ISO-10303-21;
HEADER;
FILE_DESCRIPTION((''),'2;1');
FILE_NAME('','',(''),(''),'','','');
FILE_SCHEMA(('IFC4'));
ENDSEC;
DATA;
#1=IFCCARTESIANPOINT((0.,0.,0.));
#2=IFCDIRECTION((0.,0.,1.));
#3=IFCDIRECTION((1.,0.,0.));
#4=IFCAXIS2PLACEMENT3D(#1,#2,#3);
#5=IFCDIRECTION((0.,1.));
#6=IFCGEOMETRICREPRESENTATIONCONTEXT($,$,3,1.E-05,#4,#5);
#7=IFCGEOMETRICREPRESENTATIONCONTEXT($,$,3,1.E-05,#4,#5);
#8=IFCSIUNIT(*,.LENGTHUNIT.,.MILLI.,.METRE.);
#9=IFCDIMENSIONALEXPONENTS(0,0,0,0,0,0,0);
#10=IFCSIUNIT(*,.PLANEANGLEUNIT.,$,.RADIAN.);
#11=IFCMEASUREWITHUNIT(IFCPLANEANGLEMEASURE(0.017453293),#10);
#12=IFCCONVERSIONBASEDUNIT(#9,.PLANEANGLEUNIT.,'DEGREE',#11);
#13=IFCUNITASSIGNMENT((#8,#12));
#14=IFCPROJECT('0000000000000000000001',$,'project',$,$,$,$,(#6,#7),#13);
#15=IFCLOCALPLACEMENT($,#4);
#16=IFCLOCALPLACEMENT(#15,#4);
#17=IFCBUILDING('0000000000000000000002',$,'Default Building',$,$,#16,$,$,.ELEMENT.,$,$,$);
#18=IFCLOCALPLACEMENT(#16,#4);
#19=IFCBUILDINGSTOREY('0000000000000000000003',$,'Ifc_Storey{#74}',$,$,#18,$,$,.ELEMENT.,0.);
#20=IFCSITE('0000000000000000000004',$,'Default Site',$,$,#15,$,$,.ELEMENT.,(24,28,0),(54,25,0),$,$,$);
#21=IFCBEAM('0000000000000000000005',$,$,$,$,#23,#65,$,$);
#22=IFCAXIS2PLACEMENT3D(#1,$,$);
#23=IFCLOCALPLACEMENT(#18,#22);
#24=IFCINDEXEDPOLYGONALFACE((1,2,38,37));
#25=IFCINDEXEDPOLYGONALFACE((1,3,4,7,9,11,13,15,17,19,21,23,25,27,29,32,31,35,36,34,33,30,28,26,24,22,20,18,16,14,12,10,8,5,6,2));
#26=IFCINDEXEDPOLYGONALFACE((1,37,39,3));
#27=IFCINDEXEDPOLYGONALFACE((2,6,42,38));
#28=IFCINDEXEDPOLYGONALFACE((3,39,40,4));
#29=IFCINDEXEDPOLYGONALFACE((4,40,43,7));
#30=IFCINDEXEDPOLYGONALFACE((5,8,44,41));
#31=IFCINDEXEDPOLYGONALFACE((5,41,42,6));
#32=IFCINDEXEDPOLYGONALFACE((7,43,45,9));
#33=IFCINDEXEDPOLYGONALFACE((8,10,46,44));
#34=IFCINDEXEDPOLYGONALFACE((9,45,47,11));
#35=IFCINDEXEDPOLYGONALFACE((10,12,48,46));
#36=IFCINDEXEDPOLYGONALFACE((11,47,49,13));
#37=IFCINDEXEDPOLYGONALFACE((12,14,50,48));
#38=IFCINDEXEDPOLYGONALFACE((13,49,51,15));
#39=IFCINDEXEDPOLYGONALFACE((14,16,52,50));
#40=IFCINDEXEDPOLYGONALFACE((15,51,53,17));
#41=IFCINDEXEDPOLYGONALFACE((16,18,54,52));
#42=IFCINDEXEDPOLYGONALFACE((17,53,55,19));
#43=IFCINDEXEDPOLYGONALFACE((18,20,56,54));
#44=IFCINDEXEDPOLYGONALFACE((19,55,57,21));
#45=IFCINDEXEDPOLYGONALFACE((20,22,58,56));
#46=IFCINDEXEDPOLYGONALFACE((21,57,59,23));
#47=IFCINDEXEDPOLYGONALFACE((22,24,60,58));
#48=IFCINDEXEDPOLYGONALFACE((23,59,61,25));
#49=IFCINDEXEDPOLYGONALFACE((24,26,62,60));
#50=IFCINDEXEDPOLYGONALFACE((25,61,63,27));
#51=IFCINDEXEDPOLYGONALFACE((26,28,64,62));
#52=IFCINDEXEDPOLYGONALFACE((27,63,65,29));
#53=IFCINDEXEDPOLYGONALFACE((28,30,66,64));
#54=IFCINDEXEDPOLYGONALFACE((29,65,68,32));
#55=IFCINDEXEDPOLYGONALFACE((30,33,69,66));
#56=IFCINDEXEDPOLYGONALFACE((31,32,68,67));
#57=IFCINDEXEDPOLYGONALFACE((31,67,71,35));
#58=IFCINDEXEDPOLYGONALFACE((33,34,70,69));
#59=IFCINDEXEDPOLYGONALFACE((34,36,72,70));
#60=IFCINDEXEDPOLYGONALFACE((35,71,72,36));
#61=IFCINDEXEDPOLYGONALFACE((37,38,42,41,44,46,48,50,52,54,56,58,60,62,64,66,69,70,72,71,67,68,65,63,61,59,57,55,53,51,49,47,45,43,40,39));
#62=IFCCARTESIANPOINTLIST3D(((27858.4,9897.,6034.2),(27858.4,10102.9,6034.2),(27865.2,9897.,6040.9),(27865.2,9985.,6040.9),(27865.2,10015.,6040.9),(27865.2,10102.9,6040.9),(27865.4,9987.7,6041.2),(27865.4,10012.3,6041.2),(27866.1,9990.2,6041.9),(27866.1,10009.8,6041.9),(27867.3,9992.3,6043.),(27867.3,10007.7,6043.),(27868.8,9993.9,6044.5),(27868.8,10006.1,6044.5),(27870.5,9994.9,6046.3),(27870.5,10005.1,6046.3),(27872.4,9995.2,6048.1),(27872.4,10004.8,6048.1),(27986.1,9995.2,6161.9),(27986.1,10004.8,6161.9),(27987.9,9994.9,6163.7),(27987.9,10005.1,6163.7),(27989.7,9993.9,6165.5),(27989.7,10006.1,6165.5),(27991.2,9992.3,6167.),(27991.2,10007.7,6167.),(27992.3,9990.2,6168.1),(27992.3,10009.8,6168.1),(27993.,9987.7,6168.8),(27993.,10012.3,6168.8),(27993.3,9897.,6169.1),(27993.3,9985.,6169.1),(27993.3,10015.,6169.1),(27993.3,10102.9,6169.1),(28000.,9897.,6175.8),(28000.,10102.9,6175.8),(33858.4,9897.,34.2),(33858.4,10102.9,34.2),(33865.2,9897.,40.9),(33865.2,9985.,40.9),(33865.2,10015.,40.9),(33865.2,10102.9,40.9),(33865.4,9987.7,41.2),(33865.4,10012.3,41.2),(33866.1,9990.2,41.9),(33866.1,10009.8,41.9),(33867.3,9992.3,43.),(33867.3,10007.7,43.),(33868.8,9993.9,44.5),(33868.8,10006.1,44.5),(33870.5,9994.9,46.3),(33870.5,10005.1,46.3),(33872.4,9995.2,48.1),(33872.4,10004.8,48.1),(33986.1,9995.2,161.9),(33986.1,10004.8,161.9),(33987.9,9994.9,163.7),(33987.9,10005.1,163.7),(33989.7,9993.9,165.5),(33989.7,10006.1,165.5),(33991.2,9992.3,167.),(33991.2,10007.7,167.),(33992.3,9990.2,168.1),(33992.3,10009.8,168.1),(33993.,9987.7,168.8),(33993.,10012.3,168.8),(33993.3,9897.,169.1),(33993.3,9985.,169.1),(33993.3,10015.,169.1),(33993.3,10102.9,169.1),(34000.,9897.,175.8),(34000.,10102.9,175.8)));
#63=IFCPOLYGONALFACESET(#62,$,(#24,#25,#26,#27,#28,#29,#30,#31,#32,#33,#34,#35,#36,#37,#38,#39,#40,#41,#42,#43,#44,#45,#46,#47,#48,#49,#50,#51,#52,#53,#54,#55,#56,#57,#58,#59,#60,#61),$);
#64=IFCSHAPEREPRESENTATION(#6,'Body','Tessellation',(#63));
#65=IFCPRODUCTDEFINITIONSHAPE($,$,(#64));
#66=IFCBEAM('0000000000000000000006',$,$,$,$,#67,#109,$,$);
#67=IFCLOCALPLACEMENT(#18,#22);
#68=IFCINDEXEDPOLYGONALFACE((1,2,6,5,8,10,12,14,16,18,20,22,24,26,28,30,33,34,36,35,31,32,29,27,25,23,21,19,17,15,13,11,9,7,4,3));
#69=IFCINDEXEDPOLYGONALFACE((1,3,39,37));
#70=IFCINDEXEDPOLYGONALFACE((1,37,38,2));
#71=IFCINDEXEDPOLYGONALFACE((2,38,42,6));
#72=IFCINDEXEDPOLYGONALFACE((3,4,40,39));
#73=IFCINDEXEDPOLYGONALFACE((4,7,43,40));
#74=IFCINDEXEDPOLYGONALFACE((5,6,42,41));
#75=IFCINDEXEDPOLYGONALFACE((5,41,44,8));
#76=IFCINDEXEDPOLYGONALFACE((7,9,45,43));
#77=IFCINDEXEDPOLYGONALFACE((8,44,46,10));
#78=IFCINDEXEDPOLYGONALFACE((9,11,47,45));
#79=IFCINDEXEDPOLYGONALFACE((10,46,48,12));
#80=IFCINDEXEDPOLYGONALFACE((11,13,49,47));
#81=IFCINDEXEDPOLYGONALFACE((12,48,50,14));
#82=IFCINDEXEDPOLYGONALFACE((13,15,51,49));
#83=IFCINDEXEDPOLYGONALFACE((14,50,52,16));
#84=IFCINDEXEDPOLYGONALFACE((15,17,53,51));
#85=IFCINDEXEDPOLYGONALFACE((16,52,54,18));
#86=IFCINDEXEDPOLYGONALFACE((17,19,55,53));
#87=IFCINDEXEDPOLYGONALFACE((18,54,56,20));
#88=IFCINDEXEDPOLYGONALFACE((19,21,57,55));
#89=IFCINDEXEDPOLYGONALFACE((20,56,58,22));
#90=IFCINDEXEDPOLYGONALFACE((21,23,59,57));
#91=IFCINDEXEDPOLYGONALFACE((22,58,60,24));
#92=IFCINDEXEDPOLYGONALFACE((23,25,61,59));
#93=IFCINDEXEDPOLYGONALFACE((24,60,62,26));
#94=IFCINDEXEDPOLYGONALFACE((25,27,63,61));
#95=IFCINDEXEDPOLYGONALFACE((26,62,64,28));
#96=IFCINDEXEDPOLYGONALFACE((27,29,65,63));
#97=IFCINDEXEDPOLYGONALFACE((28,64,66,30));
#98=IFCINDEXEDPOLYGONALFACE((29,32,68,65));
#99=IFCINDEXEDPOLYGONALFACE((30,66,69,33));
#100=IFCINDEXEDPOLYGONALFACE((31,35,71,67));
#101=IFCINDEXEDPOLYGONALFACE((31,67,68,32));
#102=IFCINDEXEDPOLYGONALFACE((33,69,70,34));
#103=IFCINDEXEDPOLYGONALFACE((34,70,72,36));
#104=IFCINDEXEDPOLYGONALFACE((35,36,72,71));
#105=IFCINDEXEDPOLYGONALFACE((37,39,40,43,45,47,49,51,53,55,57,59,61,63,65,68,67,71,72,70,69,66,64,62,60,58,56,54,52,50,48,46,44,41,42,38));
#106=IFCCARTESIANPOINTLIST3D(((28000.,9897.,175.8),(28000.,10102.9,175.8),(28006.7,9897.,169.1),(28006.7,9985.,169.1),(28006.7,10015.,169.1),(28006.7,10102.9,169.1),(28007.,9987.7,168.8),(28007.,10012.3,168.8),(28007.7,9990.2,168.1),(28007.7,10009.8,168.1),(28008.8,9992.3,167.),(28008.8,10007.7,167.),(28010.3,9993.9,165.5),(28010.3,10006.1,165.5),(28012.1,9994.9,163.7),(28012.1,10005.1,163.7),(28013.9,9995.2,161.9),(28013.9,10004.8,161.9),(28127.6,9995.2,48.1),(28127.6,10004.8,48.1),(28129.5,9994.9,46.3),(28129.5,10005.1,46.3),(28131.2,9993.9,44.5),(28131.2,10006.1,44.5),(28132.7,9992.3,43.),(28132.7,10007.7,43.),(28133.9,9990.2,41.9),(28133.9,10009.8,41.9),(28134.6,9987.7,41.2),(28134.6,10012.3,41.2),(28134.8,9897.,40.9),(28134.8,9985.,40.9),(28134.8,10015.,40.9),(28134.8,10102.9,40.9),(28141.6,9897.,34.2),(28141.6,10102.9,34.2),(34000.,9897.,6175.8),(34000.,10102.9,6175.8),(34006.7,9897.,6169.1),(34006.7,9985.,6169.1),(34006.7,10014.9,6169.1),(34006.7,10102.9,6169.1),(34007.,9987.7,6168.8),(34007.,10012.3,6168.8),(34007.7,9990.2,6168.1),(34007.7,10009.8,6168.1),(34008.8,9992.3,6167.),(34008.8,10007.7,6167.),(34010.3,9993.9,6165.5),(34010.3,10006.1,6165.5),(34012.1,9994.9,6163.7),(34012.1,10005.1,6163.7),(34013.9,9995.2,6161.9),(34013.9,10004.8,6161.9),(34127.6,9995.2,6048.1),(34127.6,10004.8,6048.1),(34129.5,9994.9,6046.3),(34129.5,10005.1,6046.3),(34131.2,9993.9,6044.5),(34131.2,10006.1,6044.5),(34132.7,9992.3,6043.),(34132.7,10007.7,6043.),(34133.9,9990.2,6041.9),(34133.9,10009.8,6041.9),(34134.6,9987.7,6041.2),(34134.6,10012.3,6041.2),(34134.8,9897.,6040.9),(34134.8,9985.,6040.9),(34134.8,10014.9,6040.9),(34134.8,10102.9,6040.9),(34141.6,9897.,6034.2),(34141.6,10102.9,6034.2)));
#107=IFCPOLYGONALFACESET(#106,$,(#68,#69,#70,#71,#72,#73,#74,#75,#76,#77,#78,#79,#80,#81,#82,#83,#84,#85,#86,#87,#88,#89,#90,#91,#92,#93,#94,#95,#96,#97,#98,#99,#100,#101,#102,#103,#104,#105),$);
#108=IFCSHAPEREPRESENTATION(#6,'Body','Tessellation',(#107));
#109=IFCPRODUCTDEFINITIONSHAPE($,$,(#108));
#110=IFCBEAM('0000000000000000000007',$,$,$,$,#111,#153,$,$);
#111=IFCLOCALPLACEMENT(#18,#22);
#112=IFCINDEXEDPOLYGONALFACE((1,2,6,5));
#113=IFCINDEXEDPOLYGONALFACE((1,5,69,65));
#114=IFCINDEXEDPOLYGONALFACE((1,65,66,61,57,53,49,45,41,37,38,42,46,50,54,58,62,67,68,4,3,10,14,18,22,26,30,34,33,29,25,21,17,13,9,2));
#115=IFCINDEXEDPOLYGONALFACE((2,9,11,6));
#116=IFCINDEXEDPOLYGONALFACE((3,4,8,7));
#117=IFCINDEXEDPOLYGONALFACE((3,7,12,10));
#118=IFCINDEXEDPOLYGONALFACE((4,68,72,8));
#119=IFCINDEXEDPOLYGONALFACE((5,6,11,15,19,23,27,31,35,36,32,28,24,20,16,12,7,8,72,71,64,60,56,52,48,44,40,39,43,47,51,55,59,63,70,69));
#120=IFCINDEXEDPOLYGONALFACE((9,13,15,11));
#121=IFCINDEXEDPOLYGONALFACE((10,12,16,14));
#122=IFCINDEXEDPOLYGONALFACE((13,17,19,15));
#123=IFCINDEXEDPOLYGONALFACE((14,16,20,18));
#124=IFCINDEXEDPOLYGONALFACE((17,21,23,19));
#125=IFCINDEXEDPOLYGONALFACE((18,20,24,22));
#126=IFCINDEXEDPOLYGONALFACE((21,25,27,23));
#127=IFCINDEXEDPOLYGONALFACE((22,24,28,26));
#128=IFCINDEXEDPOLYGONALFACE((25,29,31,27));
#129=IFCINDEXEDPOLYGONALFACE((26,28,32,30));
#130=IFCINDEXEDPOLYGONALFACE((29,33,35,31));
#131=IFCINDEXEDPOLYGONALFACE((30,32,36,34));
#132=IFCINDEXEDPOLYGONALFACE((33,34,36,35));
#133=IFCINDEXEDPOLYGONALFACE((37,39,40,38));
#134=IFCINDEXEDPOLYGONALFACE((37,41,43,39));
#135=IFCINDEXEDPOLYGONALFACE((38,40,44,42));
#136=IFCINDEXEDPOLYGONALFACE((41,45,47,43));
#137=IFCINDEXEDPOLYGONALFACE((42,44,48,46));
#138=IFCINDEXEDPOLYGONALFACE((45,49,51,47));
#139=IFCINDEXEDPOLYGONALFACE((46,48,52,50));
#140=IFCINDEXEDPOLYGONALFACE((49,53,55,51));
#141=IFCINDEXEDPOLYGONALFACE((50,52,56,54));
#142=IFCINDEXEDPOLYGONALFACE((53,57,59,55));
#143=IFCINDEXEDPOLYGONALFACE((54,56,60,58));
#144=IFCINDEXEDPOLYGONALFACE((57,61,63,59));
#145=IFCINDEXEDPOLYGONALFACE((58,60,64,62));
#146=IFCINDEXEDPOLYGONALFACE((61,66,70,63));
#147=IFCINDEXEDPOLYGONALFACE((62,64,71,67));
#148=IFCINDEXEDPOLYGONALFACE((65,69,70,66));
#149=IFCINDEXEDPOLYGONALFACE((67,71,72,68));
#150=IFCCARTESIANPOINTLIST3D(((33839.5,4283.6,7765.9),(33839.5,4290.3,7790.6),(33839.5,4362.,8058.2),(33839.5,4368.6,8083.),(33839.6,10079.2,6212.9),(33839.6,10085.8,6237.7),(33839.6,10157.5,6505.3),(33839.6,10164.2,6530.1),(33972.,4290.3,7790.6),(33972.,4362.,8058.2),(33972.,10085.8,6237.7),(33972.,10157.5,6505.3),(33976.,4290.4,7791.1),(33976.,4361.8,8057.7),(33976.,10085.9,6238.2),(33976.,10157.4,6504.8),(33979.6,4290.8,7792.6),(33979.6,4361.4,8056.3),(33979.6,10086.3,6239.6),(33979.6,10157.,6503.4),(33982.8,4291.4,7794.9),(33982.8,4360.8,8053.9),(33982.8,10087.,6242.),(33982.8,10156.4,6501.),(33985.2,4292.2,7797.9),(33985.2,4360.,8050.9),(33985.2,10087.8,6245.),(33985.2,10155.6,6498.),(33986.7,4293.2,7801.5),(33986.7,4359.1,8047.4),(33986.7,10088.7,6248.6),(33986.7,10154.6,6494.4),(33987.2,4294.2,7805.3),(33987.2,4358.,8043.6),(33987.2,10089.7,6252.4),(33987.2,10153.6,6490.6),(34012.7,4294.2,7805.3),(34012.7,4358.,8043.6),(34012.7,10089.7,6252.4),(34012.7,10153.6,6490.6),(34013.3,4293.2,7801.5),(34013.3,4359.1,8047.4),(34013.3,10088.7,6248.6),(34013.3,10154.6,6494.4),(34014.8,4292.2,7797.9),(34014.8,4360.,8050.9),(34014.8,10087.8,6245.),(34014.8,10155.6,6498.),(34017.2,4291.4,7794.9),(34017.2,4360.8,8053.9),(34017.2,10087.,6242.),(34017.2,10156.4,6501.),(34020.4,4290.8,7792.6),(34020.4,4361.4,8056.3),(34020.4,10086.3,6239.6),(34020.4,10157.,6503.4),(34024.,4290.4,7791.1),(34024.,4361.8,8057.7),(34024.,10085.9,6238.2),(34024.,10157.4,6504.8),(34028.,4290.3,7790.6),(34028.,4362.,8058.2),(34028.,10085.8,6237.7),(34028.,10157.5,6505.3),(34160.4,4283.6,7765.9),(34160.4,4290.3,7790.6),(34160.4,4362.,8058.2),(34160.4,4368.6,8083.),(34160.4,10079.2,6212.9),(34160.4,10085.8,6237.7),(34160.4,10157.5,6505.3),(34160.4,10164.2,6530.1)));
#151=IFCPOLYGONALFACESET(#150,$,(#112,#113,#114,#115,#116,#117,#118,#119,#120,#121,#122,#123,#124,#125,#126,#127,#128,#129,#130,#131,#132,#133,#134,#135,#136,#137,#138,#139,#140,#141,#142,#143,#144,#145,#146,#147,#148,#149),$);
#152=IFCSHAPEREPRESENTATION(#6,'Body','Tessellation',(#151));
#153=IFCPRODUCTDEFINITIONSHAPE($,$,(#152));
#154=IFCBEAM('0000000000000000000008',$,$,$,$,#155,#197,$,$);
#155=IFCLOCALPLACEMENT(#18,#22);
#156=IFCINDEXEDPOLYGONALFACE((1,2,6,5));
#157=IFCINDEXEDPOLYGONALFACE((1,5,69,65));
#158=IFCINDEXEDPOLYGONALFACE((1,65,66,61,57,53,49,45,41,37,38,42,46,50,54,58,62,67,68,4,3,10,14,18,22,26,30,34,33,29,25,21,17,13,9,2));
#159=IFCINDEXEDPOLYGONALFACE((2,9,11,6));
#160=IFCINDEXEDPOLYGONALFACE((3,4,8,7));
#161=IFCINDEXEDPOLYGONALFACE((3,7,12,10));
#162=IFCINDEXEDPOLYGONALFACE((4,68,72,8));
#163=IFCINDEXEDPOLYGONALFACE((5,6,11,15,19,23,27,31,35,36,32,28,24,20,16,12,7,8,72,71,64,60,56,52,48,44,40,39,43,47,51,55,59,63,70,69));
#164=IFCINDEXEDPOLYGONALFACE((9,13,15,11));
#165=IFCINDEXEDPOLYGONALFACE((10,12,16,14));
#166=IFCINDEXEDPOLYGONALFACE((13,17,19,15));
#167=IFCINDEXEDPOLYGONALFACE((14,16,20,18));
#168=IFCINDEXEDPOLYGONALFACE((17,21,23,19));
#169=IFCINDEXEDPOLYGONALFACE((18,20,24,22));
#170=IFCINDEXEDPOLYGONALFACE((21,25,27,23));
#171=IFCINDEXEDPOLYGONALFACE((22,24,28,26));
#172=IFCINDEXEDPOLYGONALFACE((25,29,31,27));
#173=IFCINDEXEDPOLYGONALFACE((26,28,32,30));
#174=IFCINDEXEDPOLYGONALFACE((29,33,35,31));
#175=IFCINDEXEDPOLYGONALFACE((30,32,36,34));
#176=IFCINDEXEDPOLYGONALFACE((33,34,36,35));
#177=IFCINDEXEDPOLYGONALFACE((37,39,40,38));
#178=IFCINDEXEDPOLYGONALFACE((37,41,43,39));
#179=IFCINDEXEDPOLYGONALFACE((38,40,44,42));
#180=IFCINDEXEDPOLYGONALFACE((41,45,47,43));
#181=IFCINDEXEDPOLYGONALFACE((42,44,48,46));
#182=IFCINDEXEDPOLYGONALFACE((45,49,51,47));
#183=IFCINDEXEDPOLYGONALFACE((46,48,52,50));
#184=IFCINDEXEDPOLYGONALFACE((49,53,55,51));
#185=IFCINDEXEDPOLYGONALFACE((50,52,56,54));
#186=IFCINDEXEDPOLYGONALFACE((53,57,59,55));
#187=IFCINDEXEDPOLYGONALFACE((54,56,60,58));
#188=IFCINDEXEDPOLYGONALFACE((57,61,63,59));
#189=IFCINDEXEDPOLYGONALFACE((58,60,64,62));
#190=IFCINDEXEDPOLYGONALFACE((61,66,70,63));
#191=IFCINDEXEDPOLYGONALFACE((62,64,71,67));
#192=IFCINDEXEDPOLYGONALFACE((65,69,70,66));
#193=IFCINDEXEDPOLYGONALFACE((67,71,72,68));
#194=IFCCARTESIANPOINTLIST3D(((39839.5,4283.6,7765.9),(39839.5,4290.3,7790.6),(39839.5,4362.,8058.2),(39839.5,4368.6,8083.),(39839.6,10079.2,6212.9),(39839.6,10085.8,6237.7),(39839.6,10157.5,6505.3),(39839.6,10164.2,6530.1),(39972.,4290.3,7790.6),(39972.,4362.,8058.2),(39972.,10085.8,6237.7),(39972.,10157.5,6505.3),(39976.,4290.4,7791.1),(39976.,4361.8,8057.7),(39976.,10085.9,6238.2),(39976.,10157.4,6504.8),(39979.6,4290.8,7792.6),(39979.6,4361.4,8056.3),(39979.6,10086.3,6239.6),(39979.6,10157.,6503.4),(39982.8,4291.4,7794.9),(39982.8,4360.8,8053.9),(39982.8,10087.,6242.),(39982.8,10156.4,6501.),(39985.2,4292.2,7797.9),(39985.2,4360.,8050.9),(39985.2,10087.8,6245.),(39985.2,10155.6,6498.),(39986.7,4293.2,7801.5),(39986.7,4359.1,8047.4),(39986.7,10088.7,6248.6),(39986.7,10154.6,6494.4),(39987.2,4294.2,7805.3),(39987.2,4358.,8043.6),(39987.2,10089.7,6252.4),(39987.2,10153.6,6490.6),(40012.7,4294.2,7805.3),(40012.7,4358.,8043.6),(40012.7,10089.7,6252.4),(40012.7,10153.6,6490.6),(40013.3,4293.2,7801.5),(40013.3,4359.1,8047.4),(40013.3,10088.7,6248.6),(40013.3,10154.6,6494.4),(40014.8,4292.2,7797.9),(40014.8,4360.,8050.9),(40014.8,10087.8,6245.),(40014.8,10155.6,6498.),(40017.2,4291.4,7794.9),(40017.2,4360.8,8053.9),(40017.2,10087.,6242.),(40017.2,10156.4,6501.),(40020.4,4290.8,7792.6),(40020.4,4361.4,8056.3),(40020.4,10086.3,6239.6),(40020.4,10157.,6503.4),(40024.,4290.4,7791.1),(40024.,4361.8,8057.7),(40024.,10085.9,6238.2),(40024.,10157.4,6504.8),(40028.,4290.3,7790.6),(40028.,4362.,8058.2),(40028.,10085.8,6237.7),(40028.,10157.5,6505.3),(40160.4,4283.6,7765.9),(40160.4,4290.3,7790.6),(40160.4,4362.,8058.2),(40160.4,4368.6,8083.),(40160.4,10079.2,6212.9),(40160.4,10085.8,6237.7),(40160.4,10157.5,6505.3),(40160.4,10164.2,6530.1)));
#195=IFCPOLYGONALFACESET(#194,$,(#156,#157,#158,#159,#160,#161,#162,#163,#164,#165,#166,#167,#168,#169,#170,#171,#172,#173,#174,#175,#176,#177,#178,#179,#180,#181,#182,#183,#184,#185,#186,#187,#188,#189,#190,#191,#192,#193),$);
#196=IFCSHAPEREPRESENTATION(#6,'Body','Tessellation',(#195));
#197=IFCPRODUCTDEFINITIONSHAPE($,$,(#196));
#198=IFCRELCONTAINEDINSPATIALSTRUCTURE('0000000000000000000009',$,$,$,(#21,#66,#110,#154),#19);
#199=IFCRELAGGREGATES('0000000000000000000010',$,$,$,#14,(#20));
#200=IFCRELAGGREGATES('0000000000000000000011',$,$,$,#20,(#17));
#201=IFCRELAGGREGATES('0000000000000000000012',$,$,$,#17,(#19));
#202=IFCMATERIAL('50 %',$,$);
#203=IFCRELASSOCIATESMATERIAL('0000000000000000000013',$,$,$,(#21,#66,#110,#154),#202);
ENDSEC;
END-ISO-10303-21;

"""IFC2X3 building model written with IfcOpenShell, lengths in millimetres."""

from ifc_helpers import new_model, entity, si_unit, converted_unit, direction, frame, origin_with_axes, origin_2d_with_axis, place, context, project, spatial, i_section, extrude, material, element, save


model = new_model("IFC2X3")

# Units and contexts
context_of_model_1 = context(None, 3, precision=1e-05, world=origin_with_axes(), true_north=direction((0.0, 1.0)))
context_of_model_2 = context(None, 3, precision=1e-05, world=origin_with_axes(), true_north=direction((0.0, 1.0)))
ifc_project = project(units=[si_unit("LENGTHUNIT", "METRE", prefix="MILLI"), converted_unit("PLANEANGLEUNIT", "DEGREE", entity("IfcPlaneAngleMeasure", 0.017453293), si_unit("PLANEANGLEUNIT", "RADIAN"), dimensions=[0, 0, 0, 0, 0, 0, 0])], contexts=[context_of_model_1, context_of_model_2])

# Site, building, storey
site_placement = place(None, origin_with_axes())
site = spatial("IfcSite", under=ifc_project, at=site_placement, Name="Default Site", CompositionType="ELEMENT", RefLatitude=(24, 28, 0), RefLongitude=(54, 25, 0))
building_placement = place(site_placement, origin_with_axes())
building = spatial("IfcBuilding", under=site, at=building_placement, Name="Default Building", CompositionType="ELEMENT")
storey_placement = place(building_placement, origin_with_axes())
storey = spatial("IfcBuildingStorey", under=building, at=storey_placement, Name="Ifc_Storey{#74}", CompositionType="ELEMENT", Elevation=0.0)

# Shared definitions
ifc_material_1 = material(Name="50 %")

# Beams
beam_1_placement = place(storey_placement, frame((33929.2, 10000.0, 105.0), z_axis=(0.0, 0.0, 1.0), x_axis=(1.0, 0.0, 0.0)))
element("IfcBeam", 1, at=beam_1_placement, inside=storey, material=ifc_material_1, context=context_of_model_1, shape_type="SweptSolid", body=[
    extrude(i_section(OverallWidth=205.9, OverallDepth=200.2, WebThickness=9.5, FlangeThickness=9.5, FilletRadius=10.2, at=origin_2d_with_axis()), frame((0.0, 0.0, 0.0), z_axis=(-0.707107, 0.0, 0.707107), x_axis=(0.0, 1.0, 0.0)), (0.0, 0.0, 1.0), 8485.3),
])
beam_2_placement = place(storey_placement, frame((28070.8, 10000.0, 105.0), z_axis=(0.0, 0.0, 1.0), x_axis=(1.0, 0.0, 0.0)))
element("IfcBeam", 2, at=beam_2_placement, inside=storey, material=ifc_material_1, context=context_of_model_1, shape_type="SweptSolid", body=[
    extrude(i_section(OverallWidth=205.9, OverallDepth=200.2, WebThickness=9.5, FlangeThickness=9.5, FilletRadius=10.2, at=origin_2d_with_axis()), frame((0.0, 0.0, 0.0), z_axis=(0.707107, 0.0, 0.707107), x_axis=(0.0, 1.0, 0.0)), (0.0, 0.0, 1.0), 8485.3),
])
for number, where, z_axis, x_axis in (
    (3, (34000.0, 10121.7, 6371.5), (0.0, 0.0, 1.0), (0.0, -1.0, 0.0)),
    (4, (40000.0, 10121.7, 6371.5), (0.0, 0.0, 1.0), (0.0, -1.0, 0.0)),
):
    element("IfcBeam", number, at=place(storey_placement, frame(where, z_axis=z_axis, x_axis=x_axis)), inside=storey, material=ifc_material_1, context=context_of_model_1, shape_type="SweptSolid", body=[
        extrude(i_section(OverallWidth=320.9, OverallDepth=328.3, WebThickness=25.5, FlangeThickness=25.6, FilletRadius=15.2, at=origin_2d_with_axis()), frame((0.0, 0.0, 0.0), z_axis=(0.965926, 0.0, 0.258819), x_axis=(0.0, 1.0, 0.0)), (0.0, 0.0, 1.0), 6000.0),
    ])

save(model, "model.ifc")
